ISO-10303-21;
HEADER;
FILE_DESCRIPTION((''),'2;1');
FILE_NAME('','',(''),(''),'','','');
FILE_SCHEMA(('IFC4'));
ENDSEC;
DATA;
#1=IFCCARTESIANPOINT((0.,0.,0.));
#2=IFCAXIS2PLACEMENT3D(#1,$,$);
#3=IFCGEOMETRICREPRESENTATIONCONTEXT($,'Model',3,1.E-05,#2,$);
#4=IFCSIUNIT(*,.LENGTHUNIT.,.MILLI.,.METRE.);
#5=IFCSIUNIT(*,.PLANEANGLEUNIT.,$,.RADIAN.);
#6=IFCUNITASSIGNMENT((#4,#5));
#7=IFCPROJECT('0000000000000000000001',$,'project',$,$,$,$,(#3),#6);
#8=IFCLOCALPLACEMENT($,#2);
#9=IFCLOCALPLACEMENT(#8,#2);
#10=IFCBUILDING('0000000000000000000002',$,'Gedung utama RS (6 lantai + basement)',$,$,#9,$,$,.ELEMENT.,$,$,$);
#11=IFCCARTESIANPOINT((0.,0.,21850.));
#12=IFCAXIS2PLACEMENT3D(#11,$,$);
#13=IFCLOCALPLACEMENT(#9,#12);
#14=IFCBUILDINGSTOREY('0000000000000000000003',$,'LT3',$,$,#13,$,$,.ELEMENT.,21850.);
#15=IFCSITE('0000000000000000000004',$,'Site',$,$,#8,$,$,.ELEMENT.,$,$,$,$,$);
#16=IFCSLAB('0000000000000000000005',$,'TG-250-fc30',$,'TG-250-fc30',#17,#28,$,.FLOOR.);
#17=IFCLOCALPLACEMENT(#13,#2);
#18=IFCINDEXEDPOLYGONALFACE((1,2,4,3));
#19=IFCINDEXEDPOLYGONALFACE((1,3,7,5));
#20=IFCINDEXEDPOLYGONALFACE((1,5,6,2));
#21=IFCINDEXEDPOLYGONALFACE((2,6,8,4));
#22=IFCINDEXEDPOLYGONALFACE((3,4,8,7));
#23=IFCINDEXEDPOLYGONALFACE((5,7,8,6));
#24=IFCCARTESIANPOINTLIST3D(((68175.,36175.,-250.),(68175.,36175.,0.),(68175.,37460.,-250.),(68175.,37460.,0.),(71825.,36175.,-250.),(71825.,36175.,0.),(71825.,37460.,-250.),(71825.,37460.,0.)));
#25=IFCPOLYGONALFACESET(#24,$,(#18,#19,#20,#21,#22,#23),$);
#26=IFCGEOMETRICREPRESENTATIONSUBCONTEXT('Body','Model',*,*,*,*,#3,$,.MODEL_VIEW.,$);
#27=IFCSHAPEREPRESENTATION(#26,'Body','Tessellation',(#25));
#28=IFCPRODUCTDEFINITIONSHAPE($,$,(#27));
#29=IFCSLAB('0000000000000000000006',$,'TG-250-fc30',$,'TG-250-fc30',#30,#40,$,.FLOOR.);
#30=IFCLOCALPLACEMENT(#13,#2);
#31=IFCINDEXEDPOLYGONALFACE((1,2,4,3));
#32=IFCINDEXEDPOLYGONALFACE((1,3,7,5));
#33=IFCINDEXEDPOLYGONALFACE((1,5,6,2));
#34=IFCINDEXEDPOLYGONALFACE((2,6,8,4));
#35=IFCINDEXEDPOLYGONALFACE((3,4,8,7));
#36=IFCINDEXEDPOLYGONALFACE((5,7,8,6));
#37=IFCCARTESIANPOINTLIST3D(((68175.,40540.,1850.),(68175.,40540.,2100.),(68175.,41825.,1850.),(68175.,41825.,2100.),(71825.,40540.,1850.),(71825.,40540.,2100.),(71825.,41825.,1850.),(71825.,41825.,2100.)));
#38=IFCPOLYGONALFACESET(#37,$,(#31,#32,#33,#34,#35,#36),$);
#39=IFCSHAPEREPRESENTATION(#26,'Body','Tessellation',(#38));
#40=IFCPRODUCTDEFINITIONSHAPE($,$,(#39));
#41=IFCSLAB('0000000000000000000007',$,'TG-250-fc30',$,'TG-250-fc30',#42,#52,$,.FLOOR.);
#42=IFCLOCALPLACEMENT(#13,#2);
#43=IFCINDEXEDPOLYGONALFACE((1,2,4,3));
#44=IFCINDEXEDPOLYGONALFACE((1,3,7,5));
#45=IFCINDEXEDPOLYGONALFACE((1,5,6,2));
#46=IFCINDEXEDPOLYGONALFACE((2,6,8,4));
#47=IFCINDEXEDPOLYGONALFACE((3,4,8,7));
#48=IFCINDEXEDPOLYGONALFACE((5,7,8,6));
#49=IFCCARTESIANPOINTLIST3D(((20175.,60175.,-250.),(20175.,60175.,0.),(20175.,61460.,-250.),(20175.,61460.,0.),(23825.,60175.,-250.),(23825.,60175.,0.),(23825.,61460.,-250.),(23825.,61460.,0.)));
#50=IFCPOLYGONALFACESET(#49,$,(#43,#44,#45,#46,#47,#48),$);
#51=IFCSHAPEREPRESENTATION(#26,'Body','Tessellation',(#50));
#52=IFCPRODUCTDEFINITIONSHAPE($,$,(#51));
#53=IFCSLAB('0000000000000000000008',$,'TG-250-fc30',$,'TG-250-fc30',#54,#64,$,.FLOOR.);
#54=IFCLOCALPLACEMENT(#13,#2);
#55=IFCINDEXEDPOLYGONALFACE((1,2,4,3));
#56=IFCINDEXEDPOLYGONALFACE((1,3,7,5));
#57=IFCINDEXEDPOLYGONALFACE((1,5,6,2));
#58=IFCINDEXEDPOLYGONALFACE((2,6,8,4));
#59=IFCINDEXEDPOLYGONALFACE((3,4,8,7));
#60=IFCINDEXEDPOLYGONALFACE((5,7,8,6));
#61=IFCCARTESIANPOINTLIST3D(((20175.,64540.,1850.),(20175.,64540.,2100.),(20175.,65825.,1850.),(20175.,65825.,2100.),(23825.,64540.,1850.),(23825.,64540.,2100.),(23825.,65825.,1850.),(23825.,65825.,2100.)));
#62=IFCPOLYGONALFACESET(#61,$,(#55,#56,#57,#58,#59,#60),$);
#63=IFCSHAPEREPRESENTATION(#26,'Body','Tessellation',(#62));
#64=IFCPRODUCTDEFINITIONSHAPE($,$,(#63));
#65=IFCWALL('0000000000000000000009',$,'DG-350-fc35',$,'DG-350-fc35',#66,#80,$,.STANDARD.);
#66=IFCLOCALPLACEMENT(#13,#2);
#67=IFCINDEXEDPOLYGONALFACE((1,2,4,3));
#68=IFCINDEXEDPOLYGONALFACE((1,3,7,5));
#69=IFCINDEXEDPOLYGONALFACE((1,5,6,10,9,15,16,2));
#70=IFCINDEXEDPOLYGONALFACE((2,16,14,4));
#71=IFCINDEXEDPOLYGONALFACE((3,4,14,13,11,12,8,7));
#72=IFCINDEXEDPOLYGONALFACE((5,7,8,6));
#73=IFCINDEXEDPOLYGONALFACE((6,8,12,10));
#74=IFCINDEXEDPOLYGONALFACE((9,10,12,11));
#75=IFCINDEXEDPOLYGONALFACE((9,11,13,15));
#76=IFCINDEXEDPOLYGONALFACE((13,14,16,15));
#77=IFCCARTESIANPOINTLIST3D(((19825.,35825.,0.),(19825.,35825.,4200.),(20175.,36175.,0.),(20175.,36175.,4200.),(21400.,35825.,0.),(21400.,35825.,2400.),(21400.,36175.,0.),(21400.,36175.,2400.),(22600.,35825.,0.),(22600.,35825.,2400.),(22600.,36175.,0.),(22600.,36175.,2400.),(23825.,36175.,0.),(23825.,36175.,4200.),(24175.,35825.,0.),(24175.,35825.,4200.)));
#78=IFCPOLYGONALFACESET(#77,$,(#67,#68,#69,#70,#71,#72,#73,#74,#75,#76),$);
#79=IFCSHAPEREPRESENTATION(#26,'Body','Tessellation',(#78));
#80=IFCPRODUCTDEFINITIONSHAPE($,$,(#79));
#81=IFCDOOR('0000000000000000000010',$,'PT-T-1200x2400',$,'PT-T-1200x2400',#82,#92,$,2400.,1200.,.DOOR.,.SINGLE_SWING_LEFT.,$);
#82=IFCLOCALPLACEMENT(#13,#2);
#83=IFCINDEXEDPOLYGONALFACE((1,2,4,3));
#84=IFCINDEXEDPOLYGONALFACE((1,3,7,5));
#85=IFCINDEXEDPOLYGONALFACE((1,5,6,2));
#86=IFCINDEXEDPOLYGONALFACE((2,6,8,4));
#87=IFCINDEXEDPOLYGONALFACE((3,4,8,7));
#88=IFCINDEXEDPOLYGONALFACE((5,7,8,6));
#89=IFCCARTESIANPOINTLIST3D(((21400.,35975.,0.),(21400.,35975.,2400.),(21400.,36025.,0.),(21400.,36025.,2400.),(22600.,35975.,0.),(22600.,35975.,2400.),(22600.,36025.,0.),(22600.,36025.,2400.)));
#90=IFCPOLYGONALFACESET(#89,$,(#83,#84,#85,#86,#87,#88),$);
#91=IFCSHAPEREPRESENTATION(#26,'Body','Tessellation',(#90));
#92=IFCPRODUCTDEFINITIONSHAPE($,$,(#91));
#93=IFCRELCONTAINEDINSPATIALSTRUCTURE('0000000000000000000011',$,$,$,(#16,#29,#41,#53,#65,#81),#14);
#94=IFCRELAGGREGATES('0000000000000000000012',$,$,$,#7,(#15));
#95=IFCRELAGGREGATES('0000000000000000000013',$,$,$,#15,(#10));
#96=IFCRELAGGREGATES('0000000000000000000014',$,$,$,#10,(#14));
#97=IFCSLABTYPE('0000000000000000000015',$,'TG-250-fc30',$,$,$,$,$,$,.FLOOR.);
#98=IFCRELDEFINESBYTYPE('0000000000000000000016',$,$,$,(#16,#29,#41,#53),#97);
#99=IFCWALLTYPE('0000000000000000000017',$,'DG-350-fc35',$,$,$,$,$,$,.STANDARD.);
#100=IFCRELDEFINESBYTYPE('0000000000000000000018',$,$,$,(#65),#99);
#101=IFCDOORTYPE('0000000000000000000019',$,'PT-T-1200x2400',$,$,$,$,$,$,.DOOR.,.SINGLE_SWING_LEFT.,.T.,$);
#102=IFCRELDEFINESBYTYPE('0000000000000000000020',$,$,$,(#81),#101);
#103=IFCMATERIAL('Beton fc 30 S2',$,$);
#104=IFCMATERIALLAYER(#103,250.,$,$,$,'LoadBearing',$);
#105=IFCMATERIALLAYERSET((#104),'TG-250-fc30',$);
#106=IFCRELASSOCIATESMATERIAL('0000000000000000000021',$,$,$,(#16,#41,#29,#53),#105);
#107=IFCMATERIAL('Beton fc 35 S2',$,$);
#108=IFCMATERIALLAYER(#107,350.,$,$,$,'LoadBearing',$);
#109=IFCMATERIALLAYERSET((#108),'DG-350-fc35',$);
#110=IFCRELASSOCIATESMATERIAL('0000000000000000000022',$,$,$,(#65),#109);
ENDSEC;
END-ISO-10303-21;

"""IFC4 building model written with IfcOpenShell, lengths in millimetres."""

from ifc_helpers import new_model, si_unit, frame, frame_2d, origin, place, context, subcontext, project, spatial, polyline, rectangle, outline, extrude, material, layer, layer_set, layer_usage, type_object, element, fill, save


model = new_model("IFC4")

# Units and contexts
model_context = context("Model", 3, precision=1e-05, world=origin())
body_context = subcontext(model_context, "Body", "Model", "MODEL_VIEW")
ifc_project = project(units=[si_unit("LENGTHUNIT", "METRE", prefix="MILLI"), si_unit("PLANEANGLEUNIT", "RADIAN")], contexts=[model_context])

# Site, building, storey
site_placement = place(None, origin())
site = spatial("IfcSite", under=ifc_project, at=site_placement, Name="Site", CompositionType="ELEMENT")
building_placement = place(site_placement, origin())
building = spatial("IfcBuilding", under=site, at=building_placement, Name="Gedung utama RS (6 lantai + basement)", CompositionType="ELEMENT")
storey_placement = place(building_placement, frame((0.0, 0.0, 21850.0)))
storey = spatial("IfcBuildingStorey", under=building, at=storey_placement, Name="LT3", CompositionType="ELEMENT", Elevation=21850.0)

# Shared definitions
ifc_material_1 = material(Name="Beton fc 30 S2")

# Slabs
ifc_layer_1 = layer(ifc_material_1, 250.0, Category="LoadBearing")
ifc_layer_set_1 = layer_set([ifc_layer_1], Name="TG-250-fc30")
ifc_layer_usage_1 = layer_usage(ifc_layer_set_1, "AXIS3", "NEGATIVE", 0.0)
slab_type_1 = type_object("IfcSlabType", Name="TG-250-fc30", PredefinedType="FLOOR")
ifc_layer_usage_2 = layer_usage(ifc_layer_set_1, "AXIS3", "NEGATIVE", 2100.0)
slab_1_placement = place(storey_placement, origin())
element("IfcSlab", 1, at=slab_1_placement, inside=storey, type_object=slab_type_1, material=ifc_layer_usage_1, Name="TG-250-fc30", ObjectType="TG-250-fc30", PredefinedType="FLOOR", context=body_context, shape_type="SweptSolid", body=[
    extrude(outline(polyline([(71825.0, 36175.0), (71825.0, 37460.0), (68175.0, 37460.0), (68175.0, 36175.0), (71825.0, 36175.0)])), frame((0.0, 0.0, -250.0)), (0.0, 0.0, 1.0), 250.0),
])
slab_2_placement = place(storey_placement, origin())
element("IfcSlab", 2, at=slab_2_placement, inside=storey, type_object=slab_type_1, material=ifc_layer_usage_2, Name="TG-250-fc30", ObjectType="TG-250-fc30", PredefinedType="FLOOR", context=body_context, shape_type="SweptSolid", body=[
    extrude(outline(polyline([(71825.0, 40540.0), (71825.0, 41825.0), (68175.0, 41825.0), (68175.0, 40540.0), (71825.0, 40540.0)])), frame((0.0, 0.0, 1850.0)), (0.0, 0.0, 1.0), 250.0),
])
slab_3_placement = place(storey_placement, origin())
element("IfcSlab", 3, at=slab_3_placement, inside=storey, type_object=slab_type_1, material=ifc_layer_usage_1, Name="TG-250-fc30", ObjectType="TG-250-fc30", PredefinedType="FLOOR", context=body_context, shape_type="SweptSolid", body=[
    extrude(outline(polyline([(23825.0, 60175.0), (23825.0, 61460.0), (20175.0, 61460.0), (20175.0, 60175.0), (23825.0, 60175.0)])), frame((0.0, 0.0, -250.0)), (0.0, 0.0, 1.0), 250.0),
])
slab_4_placement = place(storey_placement, origin())
element("IfcSlab", 4, at=slab_4_placement, inside=storey, type_object=slab_type_1, material=ifc_layer_usage_2, Name="TG-250-fc30", ObjectType="TG-250-fc30", PredefinedType="FLOOR", context=body_context, shape_type="SweptSolid", body=[
    extrude(outline(polyline([(23825.0, 64540.0), (23825.0, 65825.0), (20175.0, 65825.0), (20175.0, 64540.0), (23825.0, 64540.0)])), frame((0.0, 0.0, 1850.0)), (0.0, 0.0, 1.0), 250.0),
])

# Wall, opening, door
ifc_material_2 = material(Name="Beton fc 35 S2")
ifc_layer_2 = layer(ifc_material_2, 350.0, Category="LoadBearing")
ifc_layer_set_2 = layer_set([ifc_layer_2], Name="DG-350-fc35")
ifc_layer_usage_3 = layer_usage(ifc_layer_set_2, "AXIS2", "NEGATIVE", 175.0)
wall_type = type_object("IfcWallType", Name="DG-350-fc35", PredefinedType="STANDARD")
wall_placement = place(storey_placement, frame((20000.0, 36000.0, 0.0), z_axis=(0.0, 0.0, 1.0), x_axis=(1.0, 0.0, 0.0)))
wall = element("IfcWall", 5, at=wall_placement, inside=storey, type_object=wall_type, material=ifc_layer_usage_3, Name="DG-350-fc35", ObjectType="DG-350-fc35", PredefinedType="STANDARD", context=body_context, shape_type="SweptSolid", body=[
    extrude(outline(polyline([(-175.0, -175.0), (0.0, 0.0), (175.0, 175.0), (3825.0, 175.0), (4000.0, 0.0), (4175.0, -175.0), (-175.0, -175.0)])), origin(), (0.0, 0.0, 1.0), 4200.0),
])
opening_1_placement = place(wall_placement, frame((1400.0, 0.0, 0.0), z_axis=(0.0, 0.0, 1.0), x_axis=(1.0, 0.0, 0.0)))
opening_1 = element("IfcOpeningElement", 6, at=opening_1_placement, cuts=wall, PredefinedType="OPENING", context=body_context, shape_type="SweptSolid", body=[
    extrude(rectangle(XDim=1200.0, YDim=370.0, at=frame_2d((600.0, 0.0))), origin(), (0.0, 0.0, 1.0), 2400.0),
])
door_type = type_object("IfcDoorType", Name="PT-T-1200x2400", OperationType="SINGLE_SWING_LEFT", ParameterTakesPrecedence=True, PredefinedType="DOOR")
door_placement = place(opening_1_placement, origin())
door = element("IfcDoor", 7, at=door_placement, inside=storey, type_object=door_type, Name="PT-T-1200x2400", ObjectType="PT-T-1200x2400", OperationType="SINGLE_SWING_LEFT", OverallHeight=2400.0, OverallWidth=1200.0, PredefinedType="DOOR", context=body_context, shape_type="SweptSolid", body=[
    extrude(rectangle(XDim=1200.0, YDim=50.0, at=frame_2d((600.0, 0.0))), origin(), (0.0, 0.0, 1.0), 2400.0),
])
fill(opening_1, door)

save(model, "model.ifc")
